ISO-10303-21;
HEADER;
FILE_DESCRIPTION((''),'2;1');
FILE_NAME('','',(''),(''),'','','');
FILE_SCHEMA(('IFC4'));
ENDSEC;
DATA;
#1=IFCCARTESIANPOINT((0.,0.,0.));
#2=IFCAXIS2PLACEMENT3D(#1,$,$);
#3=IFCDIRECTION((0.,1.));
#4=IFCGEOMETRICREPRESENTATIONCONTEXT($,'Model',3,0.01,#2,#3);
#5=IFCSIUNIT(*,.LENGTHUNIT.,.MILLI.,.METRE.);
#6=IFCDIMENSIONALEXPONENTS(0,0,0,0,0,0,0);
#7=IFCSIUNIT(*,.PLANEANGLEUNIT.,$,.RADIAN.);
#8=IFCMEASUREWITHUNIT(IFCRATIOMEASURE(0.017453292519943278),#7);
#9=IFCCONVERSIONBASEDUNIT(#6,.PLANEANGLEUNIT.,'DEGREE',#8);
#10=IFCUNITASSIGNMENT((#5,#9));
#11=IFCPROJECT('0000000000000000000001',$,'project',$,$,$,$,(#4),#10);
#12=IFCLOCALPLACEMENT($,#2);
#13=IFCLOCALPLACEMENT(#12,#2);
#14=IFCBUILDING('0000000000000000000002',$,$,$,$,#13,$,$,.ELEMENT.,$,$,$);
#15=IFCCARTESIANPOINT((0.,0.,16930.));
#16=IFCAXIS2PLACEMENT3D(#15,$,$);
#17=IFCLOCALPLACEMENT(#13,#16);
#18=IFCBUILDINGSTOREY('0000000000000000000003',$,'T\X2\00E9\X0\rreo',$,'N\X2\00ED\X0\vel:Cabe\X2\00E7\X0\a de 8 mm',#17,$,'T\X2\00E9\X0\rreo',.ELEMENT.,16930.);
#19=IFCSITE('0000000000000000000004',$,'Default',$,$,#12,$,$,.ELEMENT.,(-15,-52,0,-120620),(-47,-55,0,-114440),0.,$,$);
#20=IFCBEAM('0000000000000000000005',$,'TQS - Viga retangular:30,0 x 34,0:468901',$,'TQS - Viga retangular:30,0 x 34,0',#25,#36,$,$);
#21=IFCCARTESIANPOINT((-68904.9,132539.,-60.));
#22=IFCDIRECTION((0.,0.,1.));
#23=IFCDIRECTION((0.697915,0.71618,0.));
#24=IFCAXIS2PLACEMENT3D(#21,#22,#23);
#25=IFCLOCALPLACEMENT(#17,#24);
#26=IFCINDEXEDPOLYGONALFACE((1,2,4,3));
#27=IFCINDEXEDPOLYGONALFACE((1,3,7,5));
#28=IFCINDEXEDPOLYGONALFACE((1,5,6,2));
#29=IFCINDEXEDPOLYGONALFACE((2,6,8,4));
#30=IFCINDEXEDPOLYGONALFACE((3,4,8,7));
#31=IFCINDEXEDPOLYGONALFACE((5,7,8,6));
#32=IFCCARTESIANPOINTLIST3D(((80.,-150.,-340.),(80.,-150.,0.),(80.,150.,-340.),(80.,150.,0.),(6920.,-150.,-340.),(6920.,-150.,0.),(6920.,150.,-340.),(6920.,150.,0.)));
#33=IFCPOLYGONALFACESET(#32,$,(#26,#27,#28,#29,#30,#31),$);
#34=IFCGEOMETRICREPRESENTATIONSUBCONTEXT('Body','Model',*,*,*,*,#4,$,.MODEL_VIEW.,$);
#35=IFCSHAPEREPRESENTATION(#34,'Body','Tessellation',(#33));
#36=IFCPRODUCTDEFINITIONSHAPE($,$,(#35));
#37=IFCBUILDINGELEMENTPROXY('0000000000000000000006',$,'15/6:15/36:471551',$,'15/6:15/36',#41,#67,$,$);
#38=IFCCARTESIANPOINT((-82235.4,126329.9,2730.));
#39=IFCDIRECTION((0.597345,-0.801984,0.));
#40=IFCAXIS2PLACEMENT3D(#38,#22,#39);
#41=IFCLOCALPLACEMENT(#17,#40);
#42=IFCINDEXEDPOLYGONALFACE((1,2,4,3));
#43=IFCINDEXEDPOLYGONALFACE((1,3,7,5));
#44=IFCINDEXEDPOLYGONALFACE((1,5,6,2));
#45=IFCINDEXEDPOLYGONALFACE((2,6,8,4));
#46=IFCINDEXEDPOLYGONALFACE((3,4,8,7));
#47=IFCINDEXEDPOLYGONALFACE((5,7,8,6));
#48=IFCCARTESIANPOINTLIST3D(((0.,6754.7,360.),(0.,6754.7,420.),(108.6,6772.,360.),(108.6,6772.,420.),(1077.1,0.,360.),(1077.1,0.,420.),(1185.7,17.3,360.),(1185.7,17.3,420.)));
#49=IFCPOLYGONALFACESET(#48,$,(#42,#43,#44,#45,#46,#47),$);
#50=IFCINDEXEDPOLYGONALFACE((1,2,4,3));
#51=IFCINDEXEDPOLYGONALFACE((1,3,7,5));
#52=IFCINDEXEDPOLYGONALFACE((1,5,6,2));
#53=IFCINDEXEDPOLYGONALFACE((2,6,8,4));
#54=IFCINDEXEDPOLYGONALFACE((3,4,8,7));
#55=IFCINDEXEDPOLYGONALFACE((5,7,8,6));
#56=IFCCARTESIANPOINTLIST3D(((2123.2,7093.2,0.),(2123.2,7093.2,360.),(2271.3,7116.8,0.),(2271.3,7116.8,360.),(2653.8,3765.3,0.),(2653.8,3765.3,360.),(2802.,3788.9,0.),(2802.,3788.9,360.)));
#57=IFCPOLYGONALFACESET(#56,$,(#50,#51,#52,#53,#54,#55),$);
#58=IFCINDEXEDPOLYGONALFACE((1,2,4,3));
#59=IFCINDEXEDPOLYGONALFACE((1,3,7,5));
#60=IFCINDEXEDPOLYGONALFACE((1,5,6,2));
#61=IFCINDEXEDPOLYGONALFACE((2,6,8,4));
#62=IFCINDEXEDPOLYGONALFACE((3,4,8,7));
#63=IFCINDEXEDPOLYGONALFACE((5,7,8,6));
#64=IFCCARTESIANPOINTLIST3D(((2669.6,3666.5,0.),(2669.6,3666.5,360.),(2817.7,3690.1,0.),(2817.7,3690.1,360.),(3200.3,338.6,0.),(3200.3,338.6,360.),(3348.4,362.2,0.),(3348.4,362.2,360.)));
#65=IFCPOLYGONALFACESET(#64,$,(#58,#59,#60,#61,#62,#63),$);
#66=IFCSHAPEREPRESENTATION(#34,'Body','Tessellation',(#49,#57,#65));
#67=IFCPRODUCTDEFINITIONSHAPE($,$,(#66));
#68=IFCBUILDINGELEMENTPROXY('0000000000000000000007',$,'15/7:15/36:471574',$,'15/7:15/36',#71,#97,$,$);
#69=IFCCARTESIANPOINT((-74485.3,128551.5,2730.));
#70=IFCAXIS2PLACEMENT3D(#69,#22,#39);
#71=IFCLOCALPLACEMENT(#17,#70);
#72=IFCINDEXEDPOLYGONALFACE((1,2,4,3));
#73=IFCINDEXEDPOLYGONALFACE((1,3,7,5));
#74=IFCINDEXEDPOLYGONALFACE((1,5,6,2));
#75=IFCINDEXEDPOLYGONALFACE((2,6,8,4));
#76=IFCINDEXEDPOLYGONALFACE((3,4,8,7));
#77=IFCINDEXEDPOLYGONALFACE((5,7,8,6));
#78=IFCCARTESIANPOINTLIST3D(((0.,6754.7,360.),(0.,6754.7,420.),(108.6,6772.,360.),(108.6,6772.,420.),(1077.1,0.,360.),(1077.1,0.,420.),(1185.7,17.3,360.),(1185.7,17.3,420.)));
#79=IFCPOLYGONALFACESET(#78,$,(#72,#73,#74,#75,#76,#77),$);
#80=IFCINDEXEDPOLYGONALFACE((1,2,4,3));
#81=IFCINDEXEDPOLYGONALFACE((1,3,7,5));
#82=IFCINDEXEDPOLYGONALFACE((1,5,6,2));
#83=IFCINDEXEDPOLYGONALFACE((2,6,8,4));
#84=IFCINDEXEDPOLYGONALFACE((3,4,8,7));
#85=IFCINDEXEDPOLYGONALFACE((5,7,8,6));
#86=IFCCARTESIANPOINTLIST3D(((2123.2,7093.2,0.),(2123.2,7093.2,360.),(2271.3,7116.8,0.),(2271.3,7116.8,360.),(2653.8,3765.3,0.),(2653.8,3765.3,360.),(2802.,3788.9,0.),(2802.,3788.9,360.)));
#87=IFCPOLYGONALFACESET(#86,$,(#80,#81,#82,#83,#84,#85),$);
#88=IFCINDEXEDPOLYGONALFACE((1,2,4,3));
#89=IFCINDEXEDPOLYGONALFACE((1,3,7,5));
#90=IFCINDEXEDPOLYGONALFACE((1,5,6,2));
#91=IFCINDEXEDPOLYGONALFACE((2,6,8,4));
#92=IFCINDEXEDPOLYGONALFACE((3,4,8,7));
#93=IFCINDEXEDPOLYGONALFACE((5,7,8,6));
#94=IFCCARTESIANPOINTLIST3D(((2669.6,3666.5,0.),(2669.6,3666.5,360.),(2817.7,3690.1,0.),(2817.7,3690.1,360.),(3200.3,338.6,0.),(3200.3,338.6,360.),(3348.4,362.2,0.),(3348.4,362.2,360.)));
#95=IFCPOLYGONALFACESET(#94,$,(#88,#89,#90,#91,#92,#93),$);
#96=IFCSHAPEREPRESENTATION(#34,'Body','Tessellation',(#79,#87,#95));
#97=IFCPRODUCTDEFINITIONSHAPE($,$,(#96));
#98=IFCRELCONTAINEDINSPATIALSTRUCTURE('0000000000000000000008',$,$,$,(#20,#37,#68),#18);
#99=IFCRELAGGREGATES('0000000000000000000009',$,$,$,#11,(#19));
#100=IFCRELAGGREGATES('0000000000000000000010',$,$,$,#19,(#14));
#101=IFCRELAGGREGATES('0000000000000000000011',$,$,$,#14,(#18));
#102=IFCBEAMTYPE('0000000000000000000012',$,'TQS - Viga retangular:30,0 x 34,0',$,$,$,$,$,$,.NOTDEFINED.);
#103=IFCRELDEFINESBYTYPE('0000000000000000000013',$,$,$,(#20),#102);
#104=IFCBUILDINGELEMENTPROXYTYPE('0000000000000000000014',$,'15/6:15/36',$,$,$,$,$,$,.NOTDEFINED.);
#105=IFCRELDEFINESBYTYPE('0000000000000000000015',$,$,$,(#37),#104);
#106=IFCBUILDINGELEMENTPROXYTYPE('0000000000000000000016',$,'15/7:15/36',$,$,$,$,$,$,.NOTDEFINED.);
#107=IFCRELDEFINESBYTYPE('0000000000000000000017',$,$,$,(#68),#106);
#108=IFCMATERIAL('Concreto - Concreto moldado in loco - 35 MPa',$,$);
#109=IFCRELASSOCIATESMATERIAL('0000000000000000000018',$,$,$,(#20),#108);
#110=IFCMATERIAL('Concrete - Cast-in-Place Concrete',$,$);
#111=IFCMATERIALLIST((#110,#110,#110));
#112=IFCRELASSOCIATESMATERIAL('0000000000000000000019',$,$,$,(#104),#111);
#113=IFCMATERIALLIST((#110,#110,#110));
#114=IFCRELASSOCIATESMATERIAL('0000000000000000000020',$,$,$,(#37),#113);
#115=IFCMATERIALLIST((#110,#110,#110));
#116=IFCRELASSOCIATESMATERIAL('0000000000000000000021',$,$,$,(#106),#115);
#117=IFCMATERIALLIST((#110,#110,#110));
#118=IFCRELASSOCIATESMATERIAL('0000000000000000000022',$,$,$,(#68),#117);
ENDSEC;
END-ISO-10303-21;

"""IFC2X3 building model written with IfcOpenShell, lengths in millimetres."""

from ifc_helpers import new_model, entity, si_unit, converted_unit, direction, frame, frame_2d, origin, place, context, subcontext, project, spatial, rectangle, extrude, source, transform, mapped, material, material_list, type_object, type_shapes, element, save


model = new_model("IFC2X3")

# Units and contexts
model_context = context("Model", 3, precision=0.01, world=origin(), true_north=direction((0.0, 1.0)))
body_context = subcontext(model_context, "Body", "Model", "MODEL_VIEW")
ifc_project = project(units=[si_unit("LENGTHUNIT", "METRE", prefix="MILLI"), converted_unit("PLANEANGLEUNIT", "DEGREE", entity("IfcRatioMeasure", 0.017453292519943278), si_unit("PLANEANGLEUNIT", "RADIAN"), dimensions=[0, 0, 0, 0, 0, 0, 0])], contexts=[model_context])

# Site, building, storey
site_placement = place(None, origin())
site = spatial("IfcSite", under=ifc_project, at=site_placement, Name="Default", CompositionType="ELEMENT", RefLatitude=(-15, -52, 0, -120620), RefLongitude=(-47, -55, 0, -114440), RefElevation=0.0)
building_placement = place(site_placement, origin())
building = spatial("IfcBuilding", under=site, at=building_placement, CompositionType="ELEMENT")
storey_placement = place(building_placement, frame((0.0, 0.0, 16930.0)))
storey = spatial("IfcBuildingStorey", under=building, at=storey_placement, Name="Térreo", ObjectType="Nível:Cabeça de 8 mm", LongName="Térreo", CompositionType="ELEMENT", Elevation=16930.0)

# Beam
ifc_material_1 = material(Name="Concreto - Concreto moldado in loco - 35 MPa")
beam_type_1 = type_object("IfcBeamType", Name="TQS - Viga retangular:30,0 x 34,0", PredefinedType="NOTDEFINED")
beam_1_placement = place(storey_placement, frame((-68904.9, 132539.0, -60.0), z_axis=(0.0, 0.0, 1.0), x_axis=(0.697915, 0.71618, 0.0)))
element("IfcBeam", 1, at=beam_1_placement, inside=storey, type_object=beam_type_1, material=ifc_material_1, Name="TQS - Viga retangular:30,0 x 34,0:468901", ObjectType="TQS - Viga retangular:30,0 x 34,0", context=body_context, shape_type="SweptSolid", body=[
    extrude(rectangle(XDim=340.0, YDim=300.0, at=frame_2d((0.0, 0.0), x_axis=(1.0, 0.0))), frame((80.0, 0.0, -170.0), z_axis=(1.0, 0.0, 0.0), x_axis=(0.0, 0.0, -1.0)), (0.0, 0.0, 1.0), 6840.0),
])

# Building element proxies
ifc_material_2 = material(Name="Concrete - Cast-in-Place Concrete")
ifc_material_list_1 = material_list([ifc_material_2, ifc_material_2, ifc_material_2])
ifc_material_list_2 = material_list([ifc_material_2, ifc_material_2, ifc_material_2])
building_element_proxy_type_1 = type_object("IfcBuildingElementProxyType", Name="15/6:15/36", PredefinedType="NOTDEFINED", material=ifc_material_list_2)
shared_shape_1 = source(origin(), body_context, "Body", "SweptSolid", [
    extrude(rectangle(XDim=110.0, YDim=6840.0, at=frame_2d((0.0, 0.0), x_axis=(1.0, 0.0))), frame((592.9, 3386.0, 360.0), z_axis=(0.0, 0.0, 1.0), x_axis=(-0.987524, -0.157469, 0.0)), (0.0, 0.0, 1.0), 60.0),
    extrude(rectangle(XDim=3370.0, YDim=150.0, at=frame_2d((0.0, 0.0), x_axis=(1.0, 0.0))), frame((2462.6, 5441.1, 0.0), z_axis=(0.0, 0.0, 1.0), x_axis=(0.157469, -0.987524, 0.0)), (0.0, 0.0, 1.0), 360.0),
    extrude(rectangle(XDim=3370.0, YDim=150.0, at=frame_2d((0.0, 0.0), x_axis=(1.0, 0.0))), frame((3009.0, 2014.3, 0.0), z_axis=(0.0, 0.0, 1.0), x_axis=(0.157469, -0.987524, 0.0)), (0.0, 0.0, 1.0), 360.0),
])
type_shapes(building_element_proxy_type_1, [shared_shape_1])
proxy_1_placement = place(storey_placement, frame((-82235.4, 126329.9, 2730.0), z_axis=(0.0, 0.0, 1.0), x_axis=(0.597345, -0.801984, 0.0)))
element("IfcBuildingElementProxy", 2, at=proxy_1_placement, inside=storey, type_object=building_element_proxy_type_1, material=ifc_material_list_1, Name="15/6:15/36:471551", ObjectType="15/6:15/36", context=body_context, shape_type="MappedRepresentation", body=[
    mapped(shared_shape_1, transform((0.0, 0.0, 0.0), scale=1.0)),
])
ifc_material_list_3 = material_list([ifc_material_2, ifc_material_2, ifc_material_2])
ifc_material_list_4 = material_list([ifc_material_2, ifc_material_2, ifc_material_2])
building_element_proxy_type_2 = type_object("IfcBuildingElementProxyType", Name="15/7:15/36", PredefinedType="NOTDEFINED", material=ifc_material_list_4)
shared_shape_2 = source(origin(), body_context, "Body", "SweptSolid", [
    extrude(rectangle(XDim=110.0, YDim=6840.0, at=frame_2d((0.0, 0.0), x_axis=(1.0, 0.0))), frame((592.9, 3386.0, 360.0), z_axis=(0.0, 0.0, 1.0), x_axis=(-0.987524, -0.157469, 0.0)), (0.0, 0.0, 1.0), 60.0),
    extrude(rectangle(XDim=3370.0, YDim=150.0, at=frame_2d((0.0, 0.0), x_axis=(1.0, 0.0))), frame((2462.6, 5441.1, 0.0), z_axis=(0.0, 0.0, 1.0), x_axis=(0.157469, -0.987524, 0.0)), (0.0, 0.0, 1.0), 360.0),
    extrude(rectangle(XDim=3370.0, YDim=150.0, at=frame_2d((0.0, 0.0), x_axis=(1.0, 0.0))), frame((3009.0, 2014.3, 0.0), z_axis=(0.0, 0.0, 1.0), x_axis=(0.157469, -0.987524, 0.0)), (0.0, 0.0, 1.0), 360.0),
])
type_shapes(building_element_proxy_type_2, [shared_shape_2])
proxy_2_placement = place(storey_placement, frame((-74485.3, 128551.5, 2730.0), z_axis=(0.0, 0.0, 1.0), x_axis=(0.597345, -0.801984, 0.0)))
element("IfcBuildingElementProxy", 3, at=proxy_2_placement, inside=storey, type_object=building_element_proxy_type_2, material=ifc_material_list_3, Name="15/7:15/36:471574", ObjectType="15/7:15/36", context=body_context, shape_type="MappedRepresentation", body=[
    mapped(shared_shape_2, transform((0.0, 0.0, 0.0), scale=1.0)),
])

save(model, "model.ifc")
